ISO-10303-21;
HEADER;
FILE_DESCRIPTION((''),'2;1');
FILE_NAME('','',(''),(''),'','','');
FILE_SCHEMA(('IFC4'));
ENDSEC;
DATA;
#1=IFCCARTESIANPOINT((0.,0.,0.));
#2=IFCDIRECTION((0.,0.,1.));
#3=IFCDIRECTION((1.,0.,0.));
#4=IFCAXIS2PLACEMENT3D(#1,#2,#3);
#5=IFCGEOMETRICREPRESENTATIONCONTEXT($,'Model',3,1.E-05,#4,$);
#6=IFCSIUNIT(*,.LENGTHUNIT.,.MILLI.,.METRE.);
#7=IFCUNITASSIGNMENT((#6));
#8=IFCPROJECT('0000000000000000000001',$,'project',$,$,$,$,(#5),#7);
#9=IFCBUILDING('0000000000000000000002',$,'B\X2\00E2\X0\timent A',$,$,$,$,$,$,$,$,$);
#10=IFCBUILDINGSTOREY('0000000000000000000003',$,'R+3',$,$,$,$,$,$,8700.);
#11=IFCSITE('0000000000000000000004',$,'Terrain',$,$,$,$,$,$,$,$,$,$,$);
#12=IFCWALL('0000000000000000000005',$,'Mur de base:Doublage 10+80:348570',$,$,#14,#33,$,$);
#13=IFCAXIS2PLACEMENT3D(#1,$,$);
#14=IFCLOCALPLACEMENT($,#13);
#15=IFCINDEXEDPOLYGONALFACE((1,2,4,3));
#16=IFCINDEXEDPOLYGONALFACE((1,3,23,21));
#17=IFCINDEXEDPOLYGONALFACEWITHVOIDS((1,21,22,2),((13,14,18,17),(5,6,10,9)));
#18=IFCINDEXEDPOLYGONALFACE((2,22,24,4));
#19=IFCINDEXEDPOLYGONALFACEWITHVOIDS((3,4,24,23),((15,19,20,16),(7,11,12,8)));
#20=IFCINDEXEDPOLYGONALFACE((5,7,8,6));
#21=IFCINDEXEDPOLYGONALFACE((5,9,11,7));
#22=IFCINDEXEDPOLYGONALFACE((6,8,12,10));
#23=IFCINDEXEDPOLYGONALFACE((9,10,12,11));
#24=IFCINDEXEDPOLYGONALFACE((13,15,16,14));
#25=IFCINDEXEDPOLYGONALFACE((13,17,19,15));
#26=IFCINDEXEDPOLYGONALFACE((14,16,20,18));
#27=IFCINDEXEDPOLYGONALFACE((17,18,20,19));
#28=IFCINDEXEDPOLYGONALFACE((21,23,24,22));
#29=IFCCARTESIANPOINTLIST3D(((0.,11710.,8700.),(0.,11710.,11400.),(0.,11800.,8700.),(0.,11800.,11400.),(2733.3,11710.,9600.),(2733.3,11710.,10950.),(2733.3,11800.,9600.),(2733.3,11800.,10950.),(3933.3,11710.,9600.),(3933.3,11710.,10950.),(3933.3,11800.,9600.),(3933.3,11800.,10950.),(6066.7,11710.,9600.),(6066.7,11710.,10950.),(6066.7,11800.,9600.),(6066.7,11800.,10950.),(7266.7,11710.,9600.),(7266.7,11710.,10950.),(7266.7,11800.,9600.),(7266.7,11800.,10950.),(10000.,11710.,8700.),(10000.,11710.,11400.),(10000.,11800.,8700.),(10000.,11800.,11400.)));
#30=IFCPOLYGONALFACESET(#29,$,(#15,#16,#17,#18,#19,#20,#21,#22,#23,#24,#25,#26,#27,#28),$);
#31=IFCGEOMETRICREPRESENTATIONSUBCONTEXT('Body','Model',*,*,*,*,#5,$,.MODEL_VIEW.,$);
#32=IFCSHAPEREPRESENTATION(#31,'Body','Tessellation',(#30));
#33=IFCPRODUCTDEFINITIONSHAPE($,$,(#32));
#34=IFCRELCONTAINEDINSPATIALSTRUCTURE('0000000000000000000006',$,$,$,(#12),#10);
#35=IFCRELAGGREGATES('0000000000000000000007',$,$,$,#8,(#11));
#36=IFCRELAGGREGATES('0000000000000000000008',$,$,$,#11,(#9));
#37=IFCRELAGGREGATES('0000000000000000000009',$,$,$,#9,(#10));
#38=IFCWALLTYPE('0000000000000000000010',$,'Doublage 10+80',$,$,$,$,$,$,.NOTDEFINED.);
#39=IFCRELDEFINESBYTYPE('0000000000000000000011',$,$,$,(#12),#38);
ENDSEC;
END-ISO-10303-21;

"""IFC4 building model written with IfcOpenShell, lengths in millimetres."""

from ifc_helpers import new_model, si_unit, frame, frame_2d, origin_with_axes, place, context, subcontext, project, spatial, rectangle, extrude, type_object, element, save


model = new_model("IFC4")

# Units and contexts
model_context = context("Model", 3, precision=1e-05, world=origin_with_axes())
body_context = subcontext(model_context, "Body", "Model", "MODEL_VIEW")
ifc_project = project(units=[si_unit("LENGTHUNIT", "METRE", prefix="MILLI")], contexts=[model_context])

# Site, building, storey
site = spatial("IfcSite", under=ifc_project, Name="Terrain")
building = spatial("IfcBuilding", under=site, Name="Bâtiment A")
storey = spatial("IfcBuildingStorey", under=building, Name="R+3", Elevation=8700.0)

# Wall, openings
wall_type_1 = type_object("IfcWallType", Name="Doublage 10+80", PredefinedType="NOTDEFINED")
wall_1_placement = place(None, origin_with_axes())
wall_1 = element("IfcWall", 1, at=wall_1_placement, inside=storey, type_object=wall_type_1, Name="Mur de base:Doublage 10+80:348570", context=body_context, shape_type="SweptSolid", body=[
    extrude(rectangle(XDim=10000.0, YDim=90.0, at=frame_2d((5000.0, 11755.0))), frame((0.0, 0.0, 8700.0), z_axis=(0.0, 0.0, 1.0), x_axis=(1.0, 0.0, 0.0)), (0.0, 0.0, 1.0), 2700.0),
])
opening_1_placement = place(None, origin_with_axes())
element("IfcOpeningElement", 2, at=opening_1_placement, cuts=wall_1, context=body_context, shape_type="SweptSolid", body=[
    extrude(rectangle(XDim=1200.0, YDim=210.0, at=frame_2d((3333.3, 11755.0))), frame((0.0, 0.0, 9600.0), z_axis=(0.0, 0.0, 1.0), x_axis=(1.0, 0.0, 0.0)), (0.0, 0.0, 1.0), 1350.0),
])
opening_2_placement = place(None, origin_with_axes())
element("IfcOpeningElement", 3, at=opening_2_placement, cuts=wall_1, context=body_context, shape_type="SweptSolid", body=[
    extrude(rectangle(XDim=1200.0, YDim=210.0, at=frame_2d((6666.7, 11755.0))), frame((0.0, 0.0, 9600.0), z_axis=(0.0, 0.0, 1.0), x_axis=(1.0, 0.0, 0.0)), (0.0, 0.0, 1.0), 1350.0),
])

save(model, "model.ifc")
